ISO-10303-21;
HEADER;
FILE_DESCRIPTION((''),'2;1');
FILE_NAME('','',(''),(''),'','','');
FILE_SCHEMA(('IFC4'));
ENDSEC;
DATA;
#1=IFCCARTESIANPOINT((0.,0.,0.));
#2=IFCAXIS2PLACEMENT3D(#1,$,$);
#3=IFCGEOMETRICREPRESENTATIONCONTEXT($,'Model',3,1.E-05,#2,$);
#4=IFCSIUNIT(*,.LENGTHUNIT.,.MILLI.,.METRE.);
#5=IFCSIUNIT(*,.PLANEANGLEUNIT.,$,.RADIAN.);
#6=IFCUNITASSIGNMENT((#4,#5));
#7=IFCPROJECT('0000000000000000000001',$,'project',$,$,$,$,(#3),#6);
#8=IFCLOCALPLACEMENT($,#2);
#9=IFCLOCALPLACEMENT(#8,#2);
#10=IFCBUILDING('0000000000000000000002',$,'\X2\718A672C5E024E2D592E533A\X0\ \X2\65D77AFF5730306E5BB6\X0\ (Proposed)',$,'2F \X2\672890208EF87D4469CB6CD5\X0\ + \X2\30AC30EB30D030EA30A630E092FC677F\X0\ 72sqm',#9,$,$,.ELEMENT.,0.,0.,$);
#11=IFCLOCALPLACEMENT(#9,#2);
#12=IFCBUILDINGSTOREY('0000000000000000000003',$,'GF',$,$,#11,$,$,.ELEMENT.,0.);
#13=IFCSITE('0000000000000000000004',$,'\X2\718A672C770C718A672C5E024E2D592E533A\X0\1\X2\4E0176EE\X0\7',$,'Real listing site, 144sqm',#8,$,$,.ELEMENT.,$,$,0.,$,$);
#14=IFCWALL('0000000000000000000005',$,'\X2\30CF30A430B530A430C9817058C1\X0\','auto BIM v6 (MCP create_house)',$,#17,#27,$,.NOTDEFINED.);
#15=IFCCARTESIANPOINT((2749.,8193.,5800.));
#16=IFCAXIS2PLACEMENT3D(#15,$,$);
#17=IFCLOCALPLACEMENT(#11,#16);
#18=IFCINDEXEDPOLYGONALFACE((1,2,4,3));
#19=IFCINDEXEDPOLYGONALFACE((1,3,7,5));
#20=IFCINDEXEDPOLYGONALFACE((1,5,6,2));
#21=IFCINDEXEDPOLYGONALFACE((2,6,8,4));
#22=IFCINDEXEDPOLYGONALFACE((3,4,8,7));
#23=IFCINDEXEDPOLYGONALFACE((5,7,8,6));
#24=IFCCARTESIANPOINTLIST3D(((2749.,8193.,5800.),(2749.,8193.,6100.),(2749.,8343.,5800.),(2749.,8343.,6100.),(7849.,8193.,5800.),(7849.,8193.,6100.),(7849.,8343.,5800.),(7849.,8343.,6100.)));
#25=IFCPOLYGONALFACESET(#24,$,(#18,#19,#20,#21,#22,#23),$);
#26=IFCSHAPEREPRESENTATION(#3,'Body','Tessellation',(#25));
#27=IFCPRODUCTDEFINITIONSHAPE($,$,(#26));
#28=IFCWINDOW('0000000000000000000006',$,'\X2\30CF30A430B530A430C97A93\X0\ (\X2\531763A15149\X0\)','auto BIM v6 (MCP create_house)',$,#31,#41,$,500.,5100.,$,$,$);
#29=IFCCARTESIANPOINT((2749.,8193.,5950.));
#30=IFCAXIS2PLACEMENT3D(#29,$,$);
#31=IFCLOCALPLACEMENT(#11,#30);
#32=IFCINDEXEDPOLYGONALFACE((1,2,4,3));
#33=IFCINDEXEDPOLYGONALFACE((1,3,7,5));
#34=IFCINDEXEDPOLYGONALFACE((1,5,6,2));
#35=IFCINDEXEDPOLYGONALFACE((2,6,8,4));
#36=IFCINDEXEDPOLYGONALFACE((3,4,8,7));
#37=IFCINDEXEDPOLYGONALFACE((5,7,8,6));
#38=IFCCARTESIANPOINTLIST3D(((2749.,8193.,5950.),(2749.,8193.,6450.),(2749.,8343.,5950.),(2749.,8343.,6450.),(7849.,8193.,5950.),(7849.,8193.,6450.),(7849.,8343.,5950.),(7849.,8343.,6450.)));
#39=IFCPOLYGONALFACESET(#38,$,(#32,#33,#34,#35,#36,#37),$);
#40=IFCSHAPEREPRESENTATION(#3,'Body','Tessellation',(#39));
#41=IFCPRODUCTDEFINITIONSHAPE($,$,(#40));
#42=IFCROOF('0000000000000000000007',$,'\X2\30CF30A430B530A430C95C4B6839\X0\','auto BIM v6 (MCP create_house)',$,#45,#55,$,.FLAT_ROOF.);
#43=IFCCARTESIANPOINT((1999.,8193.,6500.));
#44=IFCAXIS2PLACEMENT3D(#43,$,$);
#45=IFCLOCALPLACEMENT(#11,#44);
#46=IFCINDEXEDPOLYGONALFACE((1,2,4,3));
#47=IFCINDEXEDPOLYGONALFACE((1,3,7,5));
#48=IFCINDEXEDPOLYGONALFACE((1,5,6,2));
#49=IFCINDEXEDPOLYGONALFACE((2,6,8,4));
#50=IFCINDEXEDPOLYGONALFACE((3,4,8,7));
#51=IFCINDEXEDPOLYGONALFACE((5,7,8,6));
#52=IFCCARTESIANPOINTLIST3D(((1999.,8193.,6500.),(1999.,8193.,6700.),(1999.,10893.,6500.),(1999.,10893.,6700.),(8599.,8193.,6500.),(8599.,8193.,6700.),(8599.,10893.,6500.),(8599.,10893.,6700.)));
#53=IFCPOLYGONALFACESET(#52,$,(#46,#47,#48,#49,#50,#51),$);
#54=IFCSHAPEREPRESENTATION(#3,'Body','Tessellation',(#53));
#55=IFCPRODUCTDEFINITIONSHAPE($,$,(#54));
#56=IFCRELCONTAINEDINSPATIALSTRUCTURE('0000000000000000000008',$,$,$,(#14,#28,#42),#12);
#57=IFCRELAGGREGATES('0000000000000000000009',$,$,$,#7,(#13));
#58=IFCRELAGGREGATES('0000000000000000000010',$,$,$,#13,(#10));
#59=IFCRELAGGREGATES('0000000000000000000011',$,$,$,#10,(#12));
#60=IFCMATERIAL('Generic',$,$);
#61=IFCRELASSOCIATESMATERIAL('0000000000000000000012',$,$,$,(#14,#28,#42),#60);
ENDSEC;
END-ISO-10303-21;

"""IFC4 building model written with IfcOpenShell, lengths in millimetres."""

from ifc_helpers import new_model, si_unit, frame, frame_2d, origin, place, context, project, spatial, rectangle, extrude, material, element, fill, save


model = new_model("IFC4")

# Units and contexts
model_context = context("Model", 3, precision=1e-05, world=origin())
ifc_project = project(units=[si_unit("LENGTHUNIT", "METRE", prefix="MILLI"), si_unit("PLANEANGLEUNIT", "RADIAN")], contexts=[model_context])

# Site, building, storey
site_placement = place(None, origin())
site = spatial("IfcSite", under=ifc_project, at=site_placement, Name="熊本県熊本市中央区1丁目7", ObjectType="Real listing site, 144sqm", CompositionType="ELEMENT", RefElevation=0.0)
building_placement = place(site_placement, origin())
building = spatial("IfcBuilding", under=site, at=building_placement, Name="熊本市中央区 旗竿地の家 (Proposed)", ObjectType="2F 木造軸組構法 + ガルバリウム鋼板 72sqm", CompositionType="ELEMENT", ElevationOfRefHeight=0.0, ElevationOfTerrain=0.0)
storey_placement = place(building_placement, origin())
storey = spatial("IfcBuildingStorey", under=building, at=storey_placement, Name="GF", CompositionType="ELEMENT", Elevation=0.0)

# Shared definitions
ifc_material = material(Name="Generic")

# Wall, opening, window
wall_1_placement = place(storey_placement, frame((2749.0, 8193.0, 5800.0)))
wall_1 = element("IfcWall", 1, at=wall_1_placement, inside=storey, material=ifc_material, Name="ハイサイド腰壁", Description="auto BIM v6 (MCP create_house)", PredefinedType="NOTDEFINED", context=model_context, shape_type="SweptSolid", body=[
    extrude(rectangle(XDim=5100.0, YDim=150.0, at=frame_2d((2550.0, 75.0))), frame((2749.0, 8193.0, 5800.0)), (0.0, 0.0, 1.0), 700.0),
])
opening_1_placement = place(storey_placement, frame((2749.0, 8193.0, 5950.0)))
opening_1 = element("IfcOpeningElement", 2, at=opening_1_placement, cuts=wall_1, PredefinedType="NOTDEFINED", context=model_context, shape_type="SweptSolid", body=[
    extrude(rectangle(XDim=5100.0, YDim=150.0, at=frame_2d((2550.0, 75.0))), frame((2749.0, 8193.0, 5950.0)), (0.0, 0.0, 1.0), 500.0),
])
window_1_placement = place(storey_placement, frame((2749.0, 8193.0, 5950.0)))
window_1 = element("IfcWindow", 3, at=window_1_placement, inside=storey, material=ifc_material, Name="ハイサイド窓 (北採光)", Description="auto BIM v6 (MCP create_house)", OverallHeight=500.0, OverallWidth=5100.0, context=model_context, shape_type="SweptSolid", body=[
    extrude(rectangle(XDim=5100.0, YDim=150.0, at=frame_2d((2550.0, 75.0))), frame((2749.0, 8193.0, 5950.0)), (0.0, 0.0, 1.0), 500.0),
])
fill(opening_1, window_1)

# Roof
roof_placement = place(storey_placement, frame((1999.0, 8193.0, 6500.0)))
element("IfcRoof", 4, at=roof_placement, inside=storey, material=ifc_material, Name="ハイサイド屋根", Description="auto BIM v6 (MCP create_house)", PredefinedType="FLAT_ROOF", context=model_context, shape_type="SweptSolid", body=[
    extrude(rectangle(XDim=6600.0, YDim=2700.0, at=frame_2d((3300.0, 1350.0))), frame((1999.0, 8193.0, 6500.0)), (0.0, 0.0, 1.0), 200.0),
])

save(model, "model.ifc")
